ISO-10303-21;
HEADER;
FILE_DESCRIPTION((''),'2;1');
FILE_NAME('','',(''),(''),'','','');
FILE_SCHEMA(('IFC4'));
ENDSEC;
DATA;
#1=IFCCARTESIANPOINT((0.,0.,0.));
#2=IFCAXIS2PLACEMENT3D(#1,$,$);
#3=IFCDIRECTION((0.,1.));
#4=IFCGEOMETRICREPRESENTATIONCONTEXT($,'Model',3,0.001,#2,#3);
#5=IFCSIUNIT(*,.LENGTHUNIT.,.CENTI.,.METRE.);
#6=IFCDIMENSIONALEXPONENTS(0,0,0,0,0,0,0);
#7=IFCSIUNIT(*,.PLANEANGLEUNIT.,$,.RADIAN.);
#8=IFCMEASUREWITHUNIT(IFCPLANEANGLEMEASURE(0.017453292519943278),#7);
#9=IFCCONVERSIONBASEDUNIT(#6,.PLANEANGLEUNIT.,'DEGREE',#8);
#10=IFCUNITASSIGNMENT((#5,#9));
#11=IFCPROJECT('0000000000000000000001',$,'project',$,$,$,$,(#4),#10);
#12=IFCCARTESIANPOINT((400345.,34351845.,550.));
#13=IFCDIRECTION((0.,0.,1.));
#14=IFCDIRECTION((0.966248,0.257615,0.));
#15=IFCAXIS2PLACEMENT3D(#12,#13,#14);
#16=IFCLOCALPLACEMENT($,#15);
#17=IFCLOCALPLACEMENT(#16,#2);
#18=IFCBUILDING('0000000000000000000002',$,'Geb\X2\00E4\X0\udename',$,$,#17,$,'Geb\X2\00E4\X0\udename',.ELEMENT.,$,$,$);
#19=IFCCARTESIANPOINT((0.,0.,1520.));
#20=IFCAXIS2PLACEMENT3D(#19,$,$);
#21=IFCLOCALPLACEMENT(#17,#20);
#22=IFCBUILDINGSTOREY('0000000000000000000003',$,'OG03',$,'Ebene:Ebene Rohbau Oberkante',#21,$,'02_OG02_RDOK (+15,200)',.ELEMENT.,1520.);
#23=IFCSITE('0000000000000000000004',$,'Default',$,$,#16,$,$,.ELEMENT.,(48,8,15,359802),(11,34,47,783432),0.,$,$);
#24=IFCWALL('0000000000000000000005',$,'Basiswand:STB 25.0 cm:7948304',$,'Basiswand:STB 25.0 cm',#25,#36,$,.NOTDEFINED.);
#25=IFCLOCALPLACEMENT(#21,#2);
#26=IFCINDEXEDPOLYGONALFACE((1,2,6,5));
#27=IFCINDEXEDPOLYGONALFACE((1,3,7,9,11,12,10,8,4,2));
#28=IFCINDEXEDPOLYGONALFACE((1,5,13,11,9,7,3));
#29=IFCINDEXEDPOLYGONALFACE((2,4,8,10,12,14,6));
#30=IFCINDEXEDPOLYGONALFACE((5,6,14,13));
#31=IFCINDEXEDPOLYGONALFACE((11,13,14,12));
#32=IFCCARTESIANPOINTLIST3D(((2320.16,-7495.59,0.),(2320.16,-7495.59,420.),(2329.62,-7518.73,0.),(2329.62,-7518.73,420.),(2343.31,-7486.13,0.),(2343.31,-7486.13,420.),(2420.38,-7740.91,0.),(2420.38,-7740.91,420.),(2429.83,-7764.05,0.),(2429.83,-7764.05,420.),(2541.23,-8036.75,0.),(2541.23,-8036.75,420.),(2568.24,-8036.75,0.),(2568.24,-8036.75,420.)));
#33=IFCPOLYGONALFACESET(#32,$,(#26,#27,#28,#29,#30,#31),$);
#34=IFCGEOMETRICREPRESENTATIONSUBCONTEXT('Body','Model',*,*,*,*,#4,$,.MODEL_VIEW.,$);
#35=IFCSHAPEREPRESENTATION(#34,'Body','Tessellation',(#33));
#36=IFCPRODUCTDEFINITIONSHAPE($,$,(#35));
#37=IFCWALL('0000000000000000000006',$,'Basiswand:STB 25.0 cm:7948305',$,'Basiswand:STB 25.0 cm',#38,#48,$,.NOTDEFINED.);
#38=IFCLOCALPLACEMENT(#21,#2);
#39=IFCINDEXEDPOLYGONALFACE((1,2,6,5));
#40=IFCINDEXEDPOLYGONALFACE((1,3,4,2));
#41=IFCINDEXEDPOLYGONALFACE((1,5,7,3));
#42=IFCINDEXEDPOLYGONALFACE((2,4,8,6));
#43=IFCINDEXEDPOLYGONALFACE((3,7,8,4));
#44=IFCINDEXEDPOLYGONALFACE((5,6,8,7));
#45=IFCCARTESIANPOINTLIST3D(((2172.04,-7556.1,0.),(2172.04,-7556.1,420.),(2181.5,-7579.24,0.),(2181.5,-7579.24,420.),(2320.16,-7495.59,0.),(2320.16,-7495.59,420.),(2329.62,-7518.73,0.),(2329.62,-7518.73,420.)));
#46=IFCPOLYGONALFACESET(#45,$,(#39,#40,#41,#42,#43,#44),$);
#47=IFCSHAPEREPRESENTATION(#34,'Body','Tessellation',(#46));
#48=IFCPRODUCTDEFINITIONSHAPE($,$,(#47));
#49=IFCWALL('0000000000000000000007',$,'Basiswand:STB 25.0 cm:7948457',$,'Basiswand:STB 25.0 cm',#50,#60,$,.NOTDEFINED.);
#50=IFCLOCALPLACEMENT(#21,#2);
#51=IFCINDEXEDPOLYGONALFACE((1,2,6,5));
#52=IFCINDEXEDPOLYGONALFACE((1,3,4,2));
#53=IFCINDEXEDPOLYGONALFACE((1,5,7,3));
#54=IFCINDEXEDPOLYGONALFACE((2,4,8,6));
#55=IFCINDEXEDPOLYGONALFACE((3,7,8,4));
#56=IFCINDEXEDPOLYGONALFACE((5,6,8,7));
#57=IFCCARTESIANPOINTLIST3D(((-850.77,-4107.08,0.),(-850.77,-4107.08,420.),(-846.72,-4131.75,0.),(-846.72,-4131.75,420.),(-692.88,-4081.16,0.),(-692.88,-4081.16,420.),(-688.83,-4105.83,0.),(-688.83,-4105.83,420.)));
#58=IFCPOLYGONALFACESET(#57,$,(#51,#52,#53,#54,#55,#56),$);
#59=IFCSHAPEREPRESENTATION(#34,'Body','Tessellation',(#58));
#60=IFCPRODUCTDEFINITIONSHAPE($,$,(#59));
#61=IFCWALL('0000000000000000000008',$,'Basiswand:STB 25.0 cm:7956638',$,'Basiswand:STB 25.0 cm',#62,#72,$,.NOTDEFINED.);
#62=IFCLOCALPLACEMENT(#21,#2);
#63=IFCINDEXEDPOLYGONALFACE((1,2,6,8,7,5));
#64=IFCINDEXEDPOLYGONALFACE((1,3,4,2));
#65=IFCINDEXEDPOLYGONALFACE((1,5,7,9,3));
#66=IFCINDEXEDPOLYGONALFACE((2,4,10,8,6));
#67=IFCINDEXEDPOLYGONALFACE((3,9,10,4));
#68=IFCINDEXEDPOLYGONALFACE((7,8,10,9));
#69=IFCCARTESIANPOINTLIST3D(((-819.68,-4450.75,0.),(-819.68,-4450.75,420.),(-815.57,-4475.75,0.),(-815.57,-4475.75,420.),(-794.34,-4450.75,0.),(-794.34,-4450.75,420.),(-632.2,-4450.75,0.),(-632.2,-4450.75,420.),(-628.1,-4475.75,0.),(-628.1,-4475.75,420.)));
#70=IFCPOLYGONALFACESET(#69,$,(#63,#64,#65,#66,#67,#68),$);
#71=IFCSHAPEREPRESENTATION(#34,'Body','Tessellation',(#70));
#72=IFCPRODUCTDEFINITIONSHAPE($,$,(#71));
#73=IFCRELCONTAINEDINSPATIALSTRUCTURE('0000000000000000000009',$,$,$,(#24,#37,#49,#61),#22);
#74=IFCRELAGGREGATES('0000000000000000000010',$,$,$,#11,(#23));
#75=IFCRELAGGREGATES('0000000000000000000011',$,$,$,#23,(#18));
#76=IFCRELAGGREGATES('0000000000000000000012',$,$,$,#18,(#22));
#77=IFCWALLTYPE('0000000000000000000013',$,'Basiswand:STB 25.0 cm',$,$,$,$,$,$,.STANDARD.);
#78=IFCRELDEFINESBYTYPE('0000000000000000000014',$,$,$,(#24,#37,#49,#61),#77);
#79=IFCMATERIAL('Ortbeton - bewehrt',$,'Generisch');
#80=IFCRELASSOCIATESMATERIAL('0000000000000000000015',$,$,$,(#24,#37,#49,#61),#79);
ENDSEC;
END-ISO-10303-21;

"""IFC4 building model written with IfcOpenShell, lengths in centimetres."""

from ifc_helpers import new_model, entity, si_unit, converted_unit, direction, frame, origin, place, context, subcontext, project, spatial, indexed_curve, outline, extrude, material, type_object, element, save


model = new_model("IFC4")

# Units and contexts
model_context = context("Model", 3, precision=0.001, world=origin(), true_north=direction((0.0, 1.0)))
body_context = subcontext(model_context, "Body", "Model", "MODEL_VIEW")
ifc_project = project(units=[si_unit("LENGTHUNIT", "METRE", prefix="CENTI"), converted_unit("PLANEANGLEUNIT", "DEGREE", entity("IfcPlaneAngleMeasure", 0.017453292519943278), si_unit("PLANEANGLEUNIT", "RADIAN"), dimensions=[0, 0, 0, 0, 0, 0, 0])], contexts=[model_context])

# Site, building, storey
site_placement = place(None, frame((400345.0, 34351845.0, 550.0), z_axis=(0.0, 0.0, 1.0), x_axis=(0.966248, 0.257615, 0.0)))
site = spatial("IfcSite", under=ifc_project, at=site_placement, Name="Default", CompositionType="ELEMENT", RefLatitude=(48, 8, 15, 359802), RefLongitude=(11, 34, 47, 783432), RefElevation=0.0)
building_placement = place(site_placement, origin())
building = spatial("IfcBuilding", under=site, at=building_placement, Name="Gebäudename", LongName="Gebäudename", CompositionType="ELEMENT")
storey_placement = place(building_placement, frame((0.0, 0.0, 1520.0)))
storey = spatial("IfcBuildingStorey", under=building, at=storey_placement, Name="OG03", ObjectType="Ebene:Ebene Rohbau Oberkante", LongName="02_OG02_RDOK (+15,200)", CompositionType="ELEMENT", Elevation=1520.0)

# Shared definitions
ifc_material = material(Name="Ortbeton - bewehrt", Category="Generisch")

# Walls
wall_type = type_object("IfcWallType", Name="Basiswand:STB 25.0 cm", PredefinedType="STANDARD")
wall_1_placement = place(storey_placement, frame((2331.73, -7490.86, 0.0), z_axis=(0.0, 0.0, 1.0), x_axis=(0.378175, -0.925734, 0.0)))
element("IfcWall", 1, at=wall_1_placement, inside=storey, type_object=wall_type, material=ifc_material, Name="Basiswand:STB 25.0 cm:7948304", ObjectType="Basiswand:STB 25.0 cm", PredefinedType="NOTDEFINED", context=body_context, shape_type="SweptSolid", body=[
    extrude(outline(indexed_curve([(584.57, -12.5), (594.78, 12.5), (0.0, 12.5), (0.0, -12.5), (25.0, -12.5), (265.0, -12.5), (290.0, -12.5), (584.57, -12.5)], self_intersect=False)), origin(), (0.0, 0.0, 1.0), 420.0),
])
wall_2_placement = place(storey_placement, frame((2176.77, -7567.67, 0.0), z_axis=(0.0, 0.0, 1.0), x_axis=(0.925734, 0.378175, 0.0)))
element("IfcWall", 2, at=wall_2_placement, inside=storey, type_object=wall_type, material=ifc_material, Name="Basiswand:STB 25.0 cm:7948305", ObjectType="Basiswand:STB 25.0 cm", PredefinedType="NOTDEFINED", context=body_context, shape_type="SweptSolid", body=[
    extrude(outline(indexed_curve([(160.0, 12.5), (0.0, 12.5), (0.0, -12.5), (160.0, -12.5), (160.0, 12.5)], self_intersect=False)), origin(), (0.0, 0.0, 1.0), 420.0),
])
wall_3_placement = place(storey_placement, frame((-848.74, -4119.42, 0.0), z_axis=(0.0, 0.0, 1.0), x_axis=(0.986789, 0.162011, 0.0)))
element("IfcWall", 3, at=wall_3_placement, inside=storey, type_object=wall_type, material=ifc_material, Name="Basiswand:STB 25.0 cm:7948457", ObjectType="Basiswand:STB 25.0 cm", PredefinedType="NOTDEFINED", context=body_context, shape_type="SweptSolid", body=[
    extrude(outline(indexed_curve([(160.0, 12.5), (0.0, 12.5), (0.0, -12.5), (160.0, -12.5), (160.0, 12.5)], self_intersect=False)), origin(), (0.0, 0.0, 1.0), 420.0),
])
wall_4_placement = place(storey_placement, frame((-628.1, -4463.25, 0.0), z_axis=(0.0, 0.0, 1.0), x_axis=(-1.0, 0.0, 0.0)))
element("IfcWall", 4, at=wall_4_placement, inside=storey, type_object=wall_type, material=ifc_material, Name="Basiswand:STB 25.0 cm:7956638", ObjectType="Basiswand:STB 25.0 cm", PredefinedType="NOTDEFINED", context=body_context, shape_type="SweptSolid", body=[
    extrude(outline(indexed_curve([(191.58, -12.5), (187.48, 12.5), (0.0, 12.5), (4.1, -12.5), (166.25, -12.5), (191.58, -12.5)], self_intersect=False)), origin(), (0.0, 0.0, 1.0), 420.0),
])

save(model, "model.ifc")
